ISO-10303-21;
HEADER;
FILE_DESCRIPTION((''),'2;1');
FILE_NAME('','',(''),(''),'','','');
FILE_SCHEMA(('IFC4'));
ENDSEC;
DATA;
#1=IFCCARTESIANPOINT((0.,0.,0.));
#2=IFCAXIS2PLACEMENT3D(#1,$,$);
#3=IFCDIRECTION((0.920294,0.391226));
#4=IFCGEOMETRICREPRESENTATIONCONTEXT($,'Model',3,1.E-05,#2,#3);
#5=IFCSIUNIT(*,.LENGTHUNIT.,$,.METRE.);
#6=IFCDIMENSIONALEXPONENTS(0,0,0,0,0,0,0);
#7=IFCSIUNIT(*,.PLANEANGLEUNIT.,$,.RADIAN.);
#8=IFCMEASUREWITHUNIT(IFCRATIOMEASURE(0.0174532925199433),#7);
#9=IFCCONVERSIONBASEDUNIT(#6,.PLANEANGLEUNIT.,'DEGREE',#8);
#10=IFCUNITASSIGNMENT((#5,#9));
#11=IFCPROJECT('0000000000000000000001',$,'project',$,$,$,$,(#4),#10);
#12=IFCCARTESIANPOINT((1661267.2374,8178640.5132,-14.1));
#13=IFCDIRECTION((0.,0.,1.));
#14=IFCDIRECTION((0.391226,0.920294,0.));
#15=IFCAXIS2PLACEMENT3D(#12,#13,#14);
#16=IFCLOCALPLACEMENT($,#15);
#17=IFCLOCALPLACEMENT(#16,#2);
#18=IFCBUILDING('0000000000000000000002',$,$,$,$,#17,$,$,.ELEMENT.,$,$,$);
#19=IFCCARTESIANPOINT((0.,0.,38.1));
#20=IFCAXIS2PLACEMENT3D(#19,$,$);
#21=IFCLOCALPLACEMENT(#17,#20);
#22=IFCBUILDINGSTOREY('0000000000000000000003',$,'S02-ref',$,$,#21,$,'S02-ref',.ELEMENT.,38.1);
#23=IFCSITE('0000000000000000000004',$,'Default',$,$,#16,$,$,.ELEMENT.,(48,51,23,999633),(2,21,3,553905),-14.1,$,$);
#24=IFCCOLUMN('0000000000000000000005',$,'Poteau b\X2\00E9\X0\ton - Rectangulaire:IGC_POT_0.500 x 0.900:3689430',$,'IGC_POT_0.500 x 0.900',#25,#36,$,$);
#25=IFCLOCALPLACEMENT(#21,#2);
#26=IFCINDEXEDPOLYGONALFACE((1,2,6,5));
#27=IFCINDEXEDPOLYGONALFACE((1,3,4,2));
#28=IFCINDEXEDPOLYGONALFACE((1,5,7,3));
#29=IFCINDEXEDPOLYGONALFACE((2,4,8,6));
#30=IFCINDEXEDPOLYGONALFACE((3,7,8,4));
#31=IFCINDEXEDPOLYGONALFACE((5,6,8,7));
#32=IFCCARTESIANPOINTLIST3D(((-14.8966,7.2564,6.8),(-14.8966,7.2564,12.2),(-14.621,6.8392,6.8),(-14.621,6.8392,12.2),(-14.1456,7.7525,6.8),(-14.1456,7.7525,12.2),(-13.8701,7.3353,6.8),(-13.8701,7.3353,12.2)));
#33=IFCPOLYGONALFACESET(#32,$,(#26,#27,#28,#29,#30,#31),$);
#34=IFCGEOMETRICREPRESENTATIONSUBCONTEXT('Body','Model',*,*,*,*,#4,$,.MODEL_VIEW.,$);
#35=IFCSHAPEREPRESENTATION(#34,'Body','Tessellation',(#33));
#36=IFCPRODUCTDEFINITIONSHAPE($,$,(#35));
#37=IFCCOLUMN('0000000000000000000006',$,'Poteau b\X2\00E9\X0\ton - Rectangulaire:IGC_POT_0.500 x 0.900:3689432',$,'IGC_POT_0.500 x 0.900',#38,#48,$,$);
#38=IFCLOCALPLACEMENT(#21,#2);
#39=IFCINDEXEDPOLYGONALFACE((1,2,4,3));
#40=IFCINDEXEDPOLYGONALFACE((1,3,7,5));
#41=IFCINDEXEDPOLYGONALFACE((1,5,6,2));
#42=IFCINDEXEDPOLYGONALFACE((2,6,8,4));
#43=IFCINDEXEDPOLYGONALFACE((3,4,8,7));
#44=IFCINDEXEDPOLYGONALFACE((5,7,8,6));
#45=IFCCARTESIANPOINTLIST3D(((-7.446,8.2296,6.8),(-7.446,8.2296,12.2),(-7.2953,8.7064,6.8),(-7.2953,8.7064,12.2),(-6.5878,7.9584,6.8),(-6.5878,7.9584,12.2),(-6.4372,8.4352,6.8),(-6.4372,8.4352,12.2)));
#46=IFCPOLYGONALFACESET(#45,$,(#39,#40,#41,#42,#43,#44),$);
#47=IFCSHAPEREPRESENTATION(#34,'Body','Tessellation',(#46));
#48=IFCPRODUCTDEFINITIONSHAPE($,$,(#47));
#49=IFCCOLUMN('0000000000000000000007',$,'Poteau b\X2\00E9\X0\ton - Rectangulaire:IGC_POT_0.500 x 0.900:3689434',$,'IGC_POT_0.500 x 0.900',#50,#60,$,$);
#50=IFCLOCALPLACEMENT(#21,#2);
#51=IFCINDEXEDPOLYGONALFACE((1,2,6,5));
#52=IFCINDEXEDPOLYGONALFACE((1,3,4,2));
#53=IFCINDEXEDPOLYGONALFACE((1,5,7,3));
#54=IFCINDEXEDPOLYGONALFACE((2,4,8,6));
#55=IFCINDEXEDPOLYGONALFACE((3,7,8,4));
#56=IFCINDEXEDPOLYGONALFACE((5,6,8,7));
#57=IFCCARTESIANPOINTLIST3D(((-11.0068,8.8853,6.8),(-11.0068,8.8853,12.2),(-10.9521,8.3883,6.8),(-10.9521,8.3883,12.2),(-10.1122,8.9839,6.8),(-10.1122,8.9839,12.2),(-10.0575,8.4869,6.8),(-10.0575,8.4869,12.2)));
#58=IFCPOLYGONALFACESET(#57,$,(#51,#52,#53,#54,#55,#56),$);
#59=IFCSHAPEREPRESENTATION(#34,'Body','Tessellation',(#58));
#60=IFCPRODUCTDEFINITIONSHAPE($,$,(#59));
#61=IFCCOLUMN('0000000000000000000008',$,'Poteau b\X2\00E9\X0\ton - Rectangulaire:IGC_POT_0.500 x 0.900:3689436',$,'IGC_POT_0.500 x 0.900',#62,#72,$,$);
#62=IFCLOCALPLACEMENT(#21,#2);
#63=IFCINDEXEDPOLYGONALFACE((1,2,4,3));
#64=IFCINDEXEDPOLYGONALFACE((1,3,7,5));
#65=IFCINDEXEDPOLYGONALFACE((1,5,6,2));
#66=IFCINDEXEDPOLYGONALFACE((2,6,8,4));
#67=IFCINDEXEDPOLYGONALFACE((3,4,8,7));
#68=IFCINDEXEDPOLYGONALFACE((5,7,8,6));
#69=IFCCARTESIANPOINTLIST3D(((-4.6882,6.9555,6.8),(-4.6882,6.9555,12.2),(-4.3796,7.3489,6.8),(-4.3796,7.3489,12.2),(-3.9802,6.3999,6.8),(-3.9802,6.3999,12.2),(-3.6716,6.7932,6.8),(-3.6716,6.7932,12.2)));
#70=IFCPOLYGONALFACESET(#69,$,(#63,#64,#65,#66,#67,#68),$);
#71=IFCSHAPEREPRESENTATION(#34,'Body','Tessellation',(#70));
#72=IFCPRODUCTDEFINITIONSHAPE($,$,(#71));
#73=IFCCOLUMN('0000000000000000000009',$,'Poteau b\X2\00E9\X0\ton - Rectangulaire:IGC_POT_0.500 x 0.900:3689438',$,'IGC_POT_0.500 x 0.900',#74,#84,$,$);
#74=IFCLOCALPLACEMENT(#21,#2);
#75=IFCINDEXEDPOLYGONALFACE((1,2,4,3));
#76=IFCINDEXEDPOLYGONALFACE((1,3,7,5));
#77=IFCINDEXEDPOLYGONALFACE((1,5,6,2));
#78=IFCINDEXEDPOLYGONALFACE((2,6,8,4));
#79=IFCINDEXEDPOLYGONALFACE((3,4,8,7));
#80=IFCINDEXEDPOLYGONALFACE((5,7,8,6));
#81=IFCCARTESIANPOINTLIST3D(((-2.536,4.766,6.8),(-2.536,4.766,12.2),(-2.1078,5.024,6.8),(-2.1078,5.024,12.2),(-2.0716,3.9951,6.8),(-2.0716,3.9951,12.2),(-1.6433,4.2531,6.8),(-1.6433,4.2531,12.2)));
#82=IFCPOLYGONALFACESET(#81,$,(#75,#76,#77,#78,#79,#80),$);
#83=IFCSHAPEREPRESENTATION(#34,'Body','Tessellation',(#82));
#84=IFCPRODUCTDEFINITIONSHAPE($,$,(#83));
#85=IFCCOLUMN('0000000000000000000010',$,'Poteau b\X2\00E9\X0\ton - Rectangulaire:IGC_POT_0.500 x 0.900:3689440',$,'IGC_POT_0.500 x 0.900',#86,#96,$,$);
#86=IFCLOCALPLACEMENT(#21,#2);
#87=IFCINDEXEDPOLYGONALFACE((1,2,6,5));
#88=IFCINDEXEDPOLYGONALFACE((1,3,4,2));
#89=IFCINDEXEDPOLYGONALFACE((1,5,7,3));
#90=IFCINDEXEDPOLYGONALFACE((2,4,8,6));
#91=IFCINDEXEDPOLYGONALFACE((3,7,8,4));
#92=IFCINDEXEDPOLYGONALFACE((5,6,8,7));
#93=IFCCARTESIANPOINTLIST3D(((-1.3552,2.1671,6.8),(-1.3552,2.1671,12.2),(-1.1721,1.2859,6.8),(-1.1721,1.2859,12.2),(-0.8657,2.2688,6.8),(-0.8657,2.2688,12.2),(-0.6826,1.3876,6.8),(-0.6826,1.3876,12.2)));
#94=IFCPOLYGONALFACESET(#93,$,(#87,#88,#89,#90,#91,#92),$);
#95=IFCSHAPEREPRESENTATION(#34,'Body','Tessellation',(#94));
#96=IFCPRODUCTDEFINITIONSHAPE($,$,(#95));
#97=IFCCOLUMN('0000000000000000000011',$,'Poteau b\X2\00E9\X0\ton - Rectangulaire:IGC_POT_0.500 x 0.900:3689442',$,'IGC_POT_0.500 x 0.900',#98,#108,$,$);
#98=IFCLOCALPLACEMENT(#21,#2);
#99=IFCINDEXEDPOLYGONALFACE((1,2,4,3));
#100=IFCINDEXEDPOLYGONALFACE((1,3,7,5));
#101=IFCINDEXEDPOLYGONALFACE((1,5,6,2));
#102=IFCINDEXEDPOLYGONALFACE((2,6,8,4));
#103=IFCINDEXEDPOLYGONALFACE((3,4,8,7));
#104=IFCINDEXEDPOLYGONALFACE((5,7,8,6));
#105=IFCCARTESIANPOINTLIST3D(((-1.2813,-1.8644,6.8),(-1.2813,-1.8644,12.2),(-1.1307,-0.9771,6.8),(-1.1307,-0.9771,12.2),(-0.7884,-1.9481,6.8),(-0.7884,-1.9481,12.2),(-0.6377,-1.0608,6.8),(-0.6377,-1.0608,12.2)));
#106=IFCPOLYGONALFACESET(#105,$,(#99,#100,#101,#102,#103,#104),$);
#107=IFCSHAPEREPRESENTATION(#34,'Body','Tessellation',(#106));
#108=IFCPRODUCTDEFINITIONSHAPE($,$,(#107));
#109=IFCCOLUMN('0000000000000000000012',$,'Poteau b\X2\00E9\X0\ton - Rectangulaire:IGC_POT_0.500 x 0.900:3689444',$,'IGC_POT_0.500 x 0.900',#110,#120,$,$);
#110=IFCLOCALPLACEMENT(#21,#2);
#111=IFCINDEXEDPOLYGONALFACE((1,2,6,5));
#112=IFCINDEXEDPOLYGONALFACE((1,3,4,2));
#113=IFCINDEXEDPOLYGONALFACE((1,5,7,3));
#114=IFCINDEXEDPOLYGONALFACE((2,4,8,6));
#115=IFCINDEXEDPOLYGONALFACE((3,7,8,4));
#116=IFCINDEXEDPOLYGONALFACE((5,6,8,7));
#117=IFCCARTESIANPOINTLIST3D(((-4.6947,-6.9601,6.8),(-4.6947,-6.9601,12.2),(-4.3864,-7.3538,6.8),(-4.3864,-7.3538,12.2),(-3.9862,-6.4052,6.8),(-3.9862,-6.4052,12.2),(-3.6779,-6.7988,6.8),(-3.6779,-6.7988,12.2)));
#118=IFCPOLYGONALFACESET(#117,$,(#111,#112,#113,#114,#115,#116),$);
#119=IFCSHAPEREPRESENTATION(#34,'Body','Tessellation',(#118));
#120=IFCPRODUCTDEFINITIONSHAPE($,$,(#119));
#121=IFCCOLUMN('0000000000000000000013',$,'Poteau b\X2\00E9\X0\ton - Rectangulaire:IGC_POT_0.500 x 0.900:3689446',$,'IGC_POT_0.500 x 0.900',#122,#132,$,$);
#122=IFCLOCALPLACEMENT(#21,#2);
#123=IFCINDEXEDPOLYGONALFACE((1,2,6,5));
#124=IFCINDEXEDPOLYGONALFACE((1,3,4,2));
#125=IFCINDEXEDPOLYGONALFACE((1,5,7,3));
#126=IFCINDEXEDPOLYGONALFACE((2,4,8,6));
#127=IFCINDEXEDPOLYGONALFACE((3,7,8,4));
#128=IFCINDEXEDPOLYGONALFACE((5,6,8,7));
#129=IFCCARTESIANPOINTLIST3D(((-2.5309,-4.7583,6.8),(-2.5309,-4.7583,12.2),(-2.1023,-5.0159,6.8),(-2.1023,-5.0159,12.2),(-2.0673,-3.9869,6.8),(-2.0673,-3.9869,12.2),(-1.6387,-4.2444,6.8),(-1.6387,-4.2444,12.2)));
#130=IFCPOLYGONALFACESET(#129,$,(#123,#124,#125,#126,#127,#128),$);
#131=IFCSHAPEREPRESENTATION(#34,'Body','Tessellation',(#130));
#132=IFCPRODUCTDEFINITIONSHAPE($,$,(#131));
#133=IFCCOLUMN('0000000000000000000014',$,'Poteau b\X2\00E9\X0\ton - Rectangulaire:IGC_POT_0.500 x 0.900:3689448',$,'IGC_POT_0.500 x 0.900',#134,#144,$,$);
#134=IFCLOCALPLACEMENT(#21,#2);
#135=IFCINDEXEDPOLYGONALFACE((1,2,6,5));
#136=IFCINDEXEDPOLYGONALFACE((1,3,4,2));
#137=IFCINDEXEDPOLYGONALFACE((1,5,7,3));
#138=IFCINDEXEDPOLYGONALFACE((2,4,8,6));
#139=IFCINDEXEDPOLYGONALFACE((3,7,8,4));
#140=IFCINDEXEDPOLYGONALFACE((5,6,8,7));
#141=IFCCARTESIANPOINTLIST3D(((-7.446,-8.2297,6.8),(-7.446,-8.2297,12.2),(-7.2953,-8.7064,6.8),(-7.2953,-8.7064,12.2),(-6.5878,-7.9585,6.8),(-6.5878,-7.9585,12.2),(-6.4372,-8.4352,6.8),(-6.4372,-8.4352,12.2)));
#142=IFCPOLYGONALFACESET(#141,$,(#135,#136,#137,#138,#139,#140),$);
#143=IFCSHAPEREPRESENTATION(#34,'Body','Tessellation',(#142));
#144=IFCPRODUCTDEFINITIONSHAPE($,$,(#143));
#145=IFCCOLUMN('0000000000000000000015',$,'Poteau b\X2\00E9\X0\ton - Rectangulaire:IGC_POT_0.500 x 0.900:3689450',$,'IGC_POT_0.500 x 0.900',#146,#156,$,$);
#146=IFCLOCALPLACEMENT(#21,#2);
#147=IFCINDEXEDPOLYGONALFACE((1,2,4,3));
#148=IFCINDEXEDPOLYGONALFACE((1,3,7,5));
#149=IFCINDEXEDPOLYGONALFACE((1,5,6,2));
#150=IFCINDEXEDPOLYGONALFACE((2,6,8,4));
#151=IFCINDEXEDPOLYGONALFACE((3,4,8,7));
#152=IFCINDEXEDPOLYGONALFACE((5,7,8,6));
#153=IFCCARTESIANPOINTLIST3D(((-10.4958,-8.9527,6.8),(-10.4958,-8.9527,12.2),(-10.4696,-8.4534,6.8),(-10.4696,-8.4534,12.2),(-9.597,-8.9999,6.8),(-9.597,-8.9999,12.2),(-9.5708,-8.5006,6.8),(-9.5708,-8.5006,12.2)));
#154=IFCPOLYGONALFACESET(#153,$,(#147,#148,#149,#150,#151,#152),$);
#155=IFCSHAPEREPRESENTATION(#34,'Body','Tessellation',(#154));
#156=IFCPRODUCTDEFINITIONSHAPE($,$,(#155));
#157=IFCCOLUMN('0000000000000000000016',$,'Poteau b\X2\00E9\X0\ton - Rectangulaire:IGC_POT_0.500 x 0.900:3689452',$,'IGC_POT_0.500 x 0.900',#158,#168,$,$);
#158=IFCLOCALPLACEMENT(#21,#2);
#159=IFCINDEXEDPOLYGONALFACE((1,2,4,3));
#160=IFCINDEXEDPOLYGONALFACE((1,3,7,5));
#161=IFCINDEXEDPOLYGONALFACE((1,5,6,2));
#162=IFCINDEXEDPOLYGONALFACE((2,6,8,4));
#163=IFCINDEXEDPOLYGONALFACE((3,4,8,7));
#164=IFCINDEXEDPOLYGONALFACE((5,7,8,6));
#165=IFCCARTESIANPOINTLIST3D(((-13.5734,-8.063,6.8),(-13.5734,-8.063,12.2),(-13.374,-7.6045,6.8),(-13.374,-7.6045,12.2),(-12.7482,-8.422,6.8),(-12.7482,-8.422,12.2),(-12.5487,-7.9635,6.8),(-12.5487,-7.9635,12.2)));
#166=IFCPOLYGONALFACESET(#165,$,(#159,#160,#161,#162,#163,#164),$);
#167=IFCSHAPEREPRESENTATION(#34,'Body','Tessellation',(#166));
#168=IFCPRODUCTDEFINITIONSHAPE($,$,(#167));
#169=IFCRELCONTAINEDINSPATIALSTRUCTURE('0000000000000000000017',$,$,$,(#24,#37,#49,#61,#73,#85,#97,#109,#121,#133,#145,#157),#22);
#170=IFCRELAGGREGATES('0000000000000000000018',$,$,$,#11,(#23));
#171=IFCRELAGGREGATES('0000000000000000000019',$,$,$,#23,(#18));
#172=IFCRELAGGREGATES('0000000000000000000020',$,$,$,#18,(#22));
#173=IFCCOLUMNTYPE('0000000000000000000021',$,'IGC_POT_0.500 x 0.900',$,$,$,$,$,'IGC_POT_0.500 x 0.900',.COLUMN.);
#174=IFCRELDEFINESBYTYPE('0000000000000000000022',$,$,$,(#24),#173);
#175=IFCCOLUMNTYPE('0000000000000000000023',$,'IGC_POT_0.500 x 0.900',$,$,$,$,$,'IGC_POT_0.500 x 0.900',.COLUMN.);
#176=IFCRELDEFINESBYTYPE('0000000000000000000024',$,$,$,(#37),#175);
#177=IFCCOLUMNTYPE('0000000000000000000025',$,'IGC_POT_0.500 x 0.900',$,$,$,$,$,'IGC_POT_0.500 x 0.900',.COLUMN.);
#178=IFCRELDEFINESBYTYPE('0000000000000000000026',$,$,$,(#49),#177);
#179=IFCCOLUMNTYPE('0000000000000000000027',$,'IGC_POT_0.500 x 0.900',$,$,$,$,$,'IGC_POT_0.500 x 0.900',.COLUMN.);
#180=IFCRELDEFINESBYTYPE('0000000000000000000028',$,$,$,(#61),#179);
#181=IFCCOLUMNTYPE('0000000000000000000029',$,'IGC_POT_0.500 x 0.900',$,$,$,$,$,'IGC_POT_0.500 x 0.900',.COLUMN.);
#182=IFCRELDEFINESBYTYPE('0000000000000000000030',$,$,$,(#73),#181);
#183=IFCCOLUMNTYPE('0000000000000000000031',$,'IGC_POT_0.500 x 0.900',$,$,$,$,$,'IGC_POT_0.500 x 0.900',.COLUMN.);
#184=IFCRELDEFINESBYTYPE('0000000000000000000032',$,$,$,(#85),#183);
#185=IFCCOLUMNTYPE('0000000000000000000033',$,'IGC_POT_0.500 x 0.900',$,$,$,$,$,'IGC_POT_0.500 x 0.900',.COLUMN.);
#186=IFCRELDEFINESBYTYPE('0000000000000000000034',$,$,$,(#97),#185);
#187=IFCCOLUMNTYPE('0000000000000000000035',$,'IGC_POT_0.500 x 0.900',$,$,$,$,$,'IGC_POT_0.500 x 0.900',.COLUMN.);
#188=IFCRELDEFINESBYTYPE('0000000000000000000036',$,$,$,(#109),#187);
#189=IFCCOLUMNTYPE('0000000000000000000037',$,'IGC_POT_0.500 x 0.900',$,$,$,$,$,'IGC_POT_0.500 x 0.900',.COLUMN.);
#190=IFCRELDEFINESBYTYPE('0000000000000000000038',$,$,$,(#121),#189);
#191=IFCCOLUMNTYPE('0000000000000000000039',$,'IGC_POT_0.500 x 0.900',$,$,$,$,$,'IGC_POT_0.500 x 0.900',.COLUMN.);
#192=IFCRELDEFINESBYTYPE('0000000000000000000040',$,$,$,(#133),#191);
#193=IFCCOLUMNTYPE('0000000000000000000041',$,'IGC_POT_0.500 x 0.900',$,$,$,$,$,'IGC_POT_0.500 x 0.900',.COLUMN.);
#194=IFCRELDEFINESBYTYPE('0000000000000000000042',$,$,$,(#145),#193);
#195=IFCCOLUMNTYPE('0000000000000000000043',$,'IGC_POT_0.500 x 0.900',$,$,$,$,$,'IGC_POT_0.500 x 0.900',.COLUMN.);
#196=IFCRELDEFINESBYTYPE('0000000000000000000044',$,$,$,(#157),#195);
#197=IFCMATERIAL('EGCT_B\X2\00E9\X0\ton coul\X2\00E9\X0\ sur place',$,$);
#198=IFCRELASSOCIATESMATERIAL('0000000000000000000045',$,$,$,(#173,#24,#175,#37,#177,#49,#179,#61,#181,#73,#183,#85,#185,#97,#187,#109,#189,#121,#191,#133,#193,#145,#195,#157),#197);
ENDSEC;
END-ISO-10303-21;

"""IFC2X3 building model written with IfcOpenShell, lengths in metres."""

from ifc_helpers import new_model, entity, si_unit, converted_unit, direction, frame, frame_2d, origin, origin_2d_with_axis, place, context, subcontext, project, spatial, rectangle, extrude, source, transform, mapped, material, type_object, type_shapes, element, save


model = new_model("IFC2X3")

# Units and contexts
model_context = context("Model", 3, precision=1e-05, world=origin(), true_north=direction((0.920294, 0.391226)))
body_context = subcontext(model_context, "Body", "Model", "MODEL_VIEW")
ifc_project = project(units=[si_unit("LENGTHUNIT", "METRE"), converted_unit("PLANEANGLEUNIT", "DEGREE", entity("IfcRatioMeasure", 0.0174532925199433), si_unit("PLANEANGLEUNIT", "RADIAN"), dimensions=[0, 0, 0, 0, 0, 0, 0])], contexts=[model_context])

# Site, building, storey
site_placement = place(None, frame((1661267.2374, 8178640.5132, -14.1), z_axis=(0.0, 0.0, 1.0), x_axis=(0.391226, 0.920294, 0.0)))
site = spatial("IfcSite", under=ifc_project, at=site_placement, Name="Default", CompositionType="ELEMENT", RefLatitude=(48, 51, 23, 999633), RefLongitude=(2, 21, 3, 553905), RefElevation=-14.1)
building_placement = place(site_placement, origin())
building = spatial("IfcBuilding", under=site, at=building_placement, CompositionType="ELEMENT")
storey_placement = place(building_placement, frame((0.0, 0.0, 38.1)))
storey = spatial("IfcBuildingStorey", under=building, at=storey_placement, Name="S02-ref", LongName="S02-ref", CompositionType="ELEMENT", Elevation=38.1)

# Columns
ifc_material_1 = material(Name="EGCT_Béton coulé sur place")
column_type_1 = type_object("IfcColumnType", Name="IGC_POT_0.500 x 0.900", ElementType="IGC_POT_0.500 x 0.900", PredefinedType="COLUMN", material=ifc_material_1)
shared_shape_1 = source(origin(), body_context, "Body", "SweptSolid", [
    extrude(rectangle(XDim=0.5, YDim=0.9, at=origin_2d_with_axis()), frame((-14.3833, 7.2959, 44.9), z_axis=(0.0, 0.0, 1.0), x_axis=(-0.551164, 0.834397, 0.0)), (0.0, 0.0, 1.0), 5.4),
])
type_shapes(column_type_1, [shared_shape_1])
column_1_placement = place(storey_placement, frame((0.0, 0.0, -38.1)))
element("IfcColumn", 1, at=column_1_placement, inside=storey, type_object=column_type_1, material=ifc_material_1, Name="Poteau béton - Rectangulaire:IGC_POT_0.500 x 0.900:3689430", ObjectType="IGC_POT_0.500 x 0.900", context=body_context, shape_type="MappedRepresentation", body=[
    mapped(shared_shape_1, transform((0.0, 0.0, 0.0), scale=1.0)),
])
column_type_2 = type_object("IfcColumnType", Name="IGC_POT_0.500 x 0.900", ElementType="IGC_POT_0.500 x 0.900", PredefinedType="COLUMN", material=ifc_material_1)
shared_shape_2 = source(origin(), body_context, "Body", "SweptSolid", [
    extrude(rectangle(XDim=0.9, YDim=0.5, at=origin_2d_with_axis()), frame((-6.9416, 8.3324, 44.9), z_axis=(0.0, 0.0, 1.0), x_axis=(-0.953513, 0.301352, 0.0)), (0.0, 0.0, 1.0), 5.4),
])
type_shapes(column_type_2, [shared_shape_2])
column_2_placement = place(storey_placement, frame((0.0, 0.0, -38.1)))
element("IfcColumn", 2, at=column_2_placement, inside=storey, type_object=column_type_2, material=ifc_material_1, Name="Poteau béton - Rectangulaire:IGC_POT_0.500 x 0.900:3689432", ObjectType="IGC_POT_0.500 x 0.900", context=body_context, shape_type="MappedRepresentation", body=[
    mapped(shared_shape_2, transform((0.0, 0.0, 0.0), scale=1.0)),
])
column_type_3 = type_object("IfcColumnType", Name="IGC_POT_0.500 x 0.900", ElementType="IGC_POT_0.500 x 0.900", PredefinedType="COLUMN", material=ifc_material_1)
shared_shape_3 = source(origin(), body_context, "Body", "SweptSolid", [
    extrude(rectangle(XDim=0.9, YDim=0.5, at=frame_2d((0.0, 0.0), x_axis=(1.0, 0.0))), frame((-10.5321, 8.6861, 44.9), z_axis=(0.0, 0.0, 1.0), x_axis=(-0.993983, -0.10953, 0.0)), (0.0, 0.0, 1.0), 5.4),
])
type_shapes(column_type_3, [shared_shape_3])
column_3_placement = place(storey_placement, frame((0.0, 0.0, -38.1)))
element("IfcColumn", 3, at=column_3_placement, inside=storey, type_object=column_type_3, material=ifc_material_1, Name="Poteau béton - Rectangulaire:IGC_POT_0.500 x 0.900:3689434", ObjectType="IGC_POT_0.500 x 0.900", context=body_context, shape_type="MappedRepresentation", body=[
    mapped(shared_shape_3, transform((0.0, 0.0, 0.0), scale=1.0)),
])
column_type_4 = type_object("IfcColumnType", Name="IGC_POT_0.500 x 0.900", ElementType="IGC_POT_0.500 x 0.900", PredefinedType="COLUMN", material=ifc_material_1)
shared_shape_4 = source(origin(), body_context, "Body", "SweptSolid", [
    extrude(rectangle(XDim=0.9, YDim=0.5, at=frame_2d((0.0, 0.0), x_axis=(1.0, 0.0))), frame((-4.1799, 6.8744, 44.9), z_axis=(0.0, 0.0, 1.0), x_axis=(-0.786665, 0.617381, 0.0)), (0.0, 0.0, 1.0), 5.4),
])
type_shapes(column_type_4, [shared_shape_4])
column_4_placement = place(storey_placement, frame((0.0, 0.0, -38.1)))
element("IfcColumn", 4, at=column_4_placement, inside=storey, type_object=column_type_4, material=ifc_material_1, Name="Poteau béton - Rectangulaire:IGC_POT_0.500 x 0.900:3689436", ObjectType="IGC_POT_0.500 x 0.900", context=body_context, shape_type="MappedRepresentation", body=[
    mapped(shared_shape_4, transform((0.0, 0.0, 0.0), scale=1.0)),
])
column_type_5 = type_object("IfcColumnType", Name="IGC_POT_0.500 x 0.900", ElementType="IGC_POT_0.500 x 0.900", PredefinedType="COLUMN", material=ifc_material_1)
shared_shape_5 = source(origin(), body_context, "Body", "SweptSolid", [
    extrude(rectangle(XDim=0.9, YDim=0.5, at=origin_2d_with_axis()), frame((-2.0897, 4.5096, 44.9), z_axis=(0.0, 0.0, 1.0), x_axis=(-0.516043, 0.856562, 0.0)), (0.0, 0.0, 1.0), 5.4),
])
type_shapes(column_type_5, [shared_shape_5])
column_5_placement = place(storey_placement, frame((0.0, 0.0, -38.1)))
element("IfcColumn", 5, at=column_5_placement, inside=storey, type_object=column_type_5, material=ifc_material_1, Name="Poteau béton - Rectangulaire:IGC_POT_0.500 x 0.900:3689438", ObjectType="IGC_POT_0.500 x 0.900", context=body_context, shape_type="MappedRepresentation", body=[
    mapped(shared_shape_5, transform((0.0, 0.0, 0.0), scale=1.0)),
])
column_type_6 = type_object("IfcColumnType", Name="IGC_POT_0.500 x 0.900", ElementType="IGC_POT_0.500 x 0.900", PredefinedType="COLUMN", material=ifc_material_1)
shared_shape_6 = source(origin(), body_context, "Body", "SweptSolid", [
    extrude(rectangle(XDim=0.9, YDim=0.5, at=origin_2d_with_axis()), frame((-1.0189, 1.7774, 44.9), z_axis=(0.0, 0.0, 1.0), x_axis=(-0.203394, 0.979097, 0.0)), (0.0, 0.0, 1.0), 5.4),
])
type_shapes(column_type_6, [shared_shape_6])
column_6_placement = place(storey_placement, frame((0.0, 0.0, -38.1)))
element("IfcColumn", 6, at=column_6_placement, inside=storey, type_object=column_type_6, material=ifc_material_1, Name="Poteau béton - Rectangulaire:IGC_POT_0.500 x 0.900:3689440", ObjectType="IGC_POT_0.500 x 0.900", context=body_context, shape_type="MappedRepresentation", body=[
    mapped(shared_shape_6, transform((0.0, 0.0, 0.0), scale=1.0)),
])
column_type_7 = type_object("IfcColumnType", Name="IGC_POT_0.500 x 0.900", ElementType="IGC_POT_0.500 x 0.900", PredefinedType="COLUMN", material=ifc_material_1)
shared_shape_7 = source(origin(), body_context, "Body", "SweptSolid", [
    extrude(rectangle(XDim=0.9, YDim=0.5, at=frame_2d((0.0, 0.0), x_axis=(1.0, 0.0))), frame((-0.9595, -1.4626, 44.9), z_axis=(0.0, 0.0, 1.0), x_axis=(0.167362, 0.985895, 0.0)), (0.0, 0.0, 1.0), 5.4),
])
type_shapes(column_type_7, [shared_shape_7])
column_7_placement = place(storey_placement, frame((0.0, 0.0, -38.1)))
element("IfcColumn", 7, at=column_7_placement, inside=storey, type_object=column_type_7, material=ifc_material_1, Name="Poteau béton - Rectangulaire:IGC_POT_0.500 x 0.900:3689442", ObjectType="IGC_POT_0.500 x 0.900", context=body_context, shape_type="MappedRepresentation", body=[
    mapped(shared_shape_7, transform((0.0, 0.0, 0.0), scale=1.0)),
])
column_type_8 = type_object("IfcColumnType", Name="IGC_POT_0.500 x 0.900", ElementType="IGC_POT_0.500 x 0.900", PredefinedType="COLUMN", material=ifc_material_1)
shared_shape_8 = source(origin(), body_context, "Body", "SweptSolid", [
    extrude(rectangle(XDim=0.9, YDim=0.5, at=origin_2d_with_axis()), frame((-4.1863, -6.8795, 44.9), z_axis=(0.0, 0.0, 1.0), x_axis=(0.787239, 0.616648, 0.0)), (0.0, 0.0, 1.0), 5.4),
])
type_shapes(column_type_8, [shared_shape_8])
column_8_placement = place(storey_placement, frame((0.0, 0.0, -38.1)))
element("IfcColumn", 8, at=column_8_placement, inside=storey, type_object=column_type_8, material=ifc_material_1, Name="Poteau béton - Rectangulaire:IGC_POT_0.500 x 0.900:3689444", ObjectType="IGC_POT_0.500 x 0.900", context=body_context, shape_type="MappedRepresentation", body=[
    mapped(shared_shape_8, transform((0.0, 0.0, 0.0), scale=1.0)),
])
column_type_9 = type_object("IfcColumnType", Name="IGC_POT_0.500 x 0.900", ElementType="IGC_POT_0.500 x 0.900", PredefinedType="COLUMN", material=ifc_material_1)
shared_shape_9 = source(origin(), body_context, "Body", "SweptSolid", [
    extrude(rectangle(XDim=0.9, YDim=0.5, at=frame_2d((0.0, 0.0), x_axis=(1.0, 0.0))), frame((-2.0848, -4.5014, 44.9), z_axis=(0.0, 0.0, 1.0), x_axis=(0.515106, 0.857126, 0.0)), (0.0, 0.0, 1.0), 5.4),
])
type_shapes(column_type_9, [shared_shape_9])
column_9_placement = place(storey_placement, frame((0.0, 0.0, -38.1)))
element("IfcColumn", 9, at=column_9_placement, inside=storey, type_object=column_type_9, material=ifc_material_1, Name="Poteau béton - Rectangulaire:IGC_POT_0.500 x 0.900:3689446", ObjectType="IGC_POT_0.500 x 0.900", context=body_context, shape_type="MappedRepresentation", body=[
    mapped(shared_shape_9, transform((0.0, 0.0, 0.0), scale=1.0)),
])
column_type_10 = type_object("IfcColumnType", Name="IGC_POT_0.500 x 0.900", ElementType="IGC_POT_0.500 x 0.900", PredefinedType="COLUMN", material=ifc_material_1)
shared_shape_10 = source(origin(), body_context, "Body", "SweptSolid", [
    extrude(rectangle(XDim=0.5, YDim=0.9, at=origin_2d_with_axis()), frame((-6.9416, -8.3325, 44.9), z_axis=(0.0, 0.0, 1.0), x_axis=(-0.301353, 0.953513, 0.0)), (0.0, 0.0, 1.0), 5.4),
])
type_shapes(column_type_10, [shared_shape_10])
column_10_placement = place(storey_placement, frame((0.0, 0.0, -38.1)))
element("IfcColumn", 10, at=column_10_placement, inside=storey, type_object=column_type_10, material=ifc_material_1, Name="Poteau béton - Rectangulaire:IGC_POT_0.500 x 0.900:3689448", ObjectType="IGC_POT_0.500 x 0.900", context=body_context, shape_type="MappedRepresentation", body=[
    mapped(shared_shape_10, transform((0.0, 0.0, 0.0), scale=1.0)),
])
column_type_11 = type_object("IfcColumnType", Name="IGC_POT_0.500 x 0.900", ElementType="IGC_POT_0.500 x 0.900", PredefinedType="COLUMN", material=ifc_material_1)
shared_shape_11 = source(origin(), body_context, "Body", "SweptSolid", [
    extrude(rectangle(XDim=0.5, YDim=0.9, at=frame_2d((0.0, 0.0), x_axis=(1.0, 0.0))), frame((-10.0333, -8.7267, 44.9), z_axis=(0.0, 0.0, 1.0), x_axis=(0.052447, 0.998624, 0.0)), (0.0, 0.0, 1.0), 5.4),
])
type_shapes(column_type_11, [shared_shape_11])
column_11_placement = place(storey_placement, frame((0.0, 0.0, -38.1)))
element("IfcColumn", 11, at=column_11_placement, inside=storey, type_object=column_type_11, material=ifc_material_1, Name="Poteau béton - Rectangulaire:IGC_POT_0.500 x 0.900:3689450", ObjectType="IGC_POT_0.500 x 0.900", context=body_context, shape_type="MappedRepresentation", body=[
    mapped(shared_shape_11, transform((0.0, 0.0, 0.0), scale=1.0)),
])
column_type_12 = type_object("IfcColumnType", Name="IGC_POT_0.500 x 0.900", ElementType="IGC_POT_0.500 x 0.900", PredefinedType="COLUMN", material=ifc_material_1)
shared_shape_12 = source(origin(), body_context, "Body", "SweptSolid", [
    extrude(rectangle(XDim=0.9, YDim=0.5, at=frame_2d((0.0, 0.0), x_axis=(1.0, 0.0))), frame((-13.0611, -8.0132, 44.9), z_axis=(0.0, 0.0, 1.0), x_axis=(-0.916984, 0.398923, 0.0)), (0.0, 0.0, 1.0), 5.4),
])
type_shapes(column_type_12, [shared_shape_12])
column_12_placement = place(storey_placement, frame((0.0, 0.0, -38.1)))
element("IfcColumn", 12, at=column_12_placement, inside=storey, type_object=column_type_12, material=ifc_material_1, Name="Poteau béton - Rectangulaire:IGC_POT_0.500 x 0.900:3689452", ObjectType="IGC_POT_0.500 x 0.900", context=body_context, shape_type="MappedRepresentation", body=[
    mapped(shared_shape_12, transform((0.0, 0.0, 0.0), scale=1.0)),
])

save(model, "model.ifc")
